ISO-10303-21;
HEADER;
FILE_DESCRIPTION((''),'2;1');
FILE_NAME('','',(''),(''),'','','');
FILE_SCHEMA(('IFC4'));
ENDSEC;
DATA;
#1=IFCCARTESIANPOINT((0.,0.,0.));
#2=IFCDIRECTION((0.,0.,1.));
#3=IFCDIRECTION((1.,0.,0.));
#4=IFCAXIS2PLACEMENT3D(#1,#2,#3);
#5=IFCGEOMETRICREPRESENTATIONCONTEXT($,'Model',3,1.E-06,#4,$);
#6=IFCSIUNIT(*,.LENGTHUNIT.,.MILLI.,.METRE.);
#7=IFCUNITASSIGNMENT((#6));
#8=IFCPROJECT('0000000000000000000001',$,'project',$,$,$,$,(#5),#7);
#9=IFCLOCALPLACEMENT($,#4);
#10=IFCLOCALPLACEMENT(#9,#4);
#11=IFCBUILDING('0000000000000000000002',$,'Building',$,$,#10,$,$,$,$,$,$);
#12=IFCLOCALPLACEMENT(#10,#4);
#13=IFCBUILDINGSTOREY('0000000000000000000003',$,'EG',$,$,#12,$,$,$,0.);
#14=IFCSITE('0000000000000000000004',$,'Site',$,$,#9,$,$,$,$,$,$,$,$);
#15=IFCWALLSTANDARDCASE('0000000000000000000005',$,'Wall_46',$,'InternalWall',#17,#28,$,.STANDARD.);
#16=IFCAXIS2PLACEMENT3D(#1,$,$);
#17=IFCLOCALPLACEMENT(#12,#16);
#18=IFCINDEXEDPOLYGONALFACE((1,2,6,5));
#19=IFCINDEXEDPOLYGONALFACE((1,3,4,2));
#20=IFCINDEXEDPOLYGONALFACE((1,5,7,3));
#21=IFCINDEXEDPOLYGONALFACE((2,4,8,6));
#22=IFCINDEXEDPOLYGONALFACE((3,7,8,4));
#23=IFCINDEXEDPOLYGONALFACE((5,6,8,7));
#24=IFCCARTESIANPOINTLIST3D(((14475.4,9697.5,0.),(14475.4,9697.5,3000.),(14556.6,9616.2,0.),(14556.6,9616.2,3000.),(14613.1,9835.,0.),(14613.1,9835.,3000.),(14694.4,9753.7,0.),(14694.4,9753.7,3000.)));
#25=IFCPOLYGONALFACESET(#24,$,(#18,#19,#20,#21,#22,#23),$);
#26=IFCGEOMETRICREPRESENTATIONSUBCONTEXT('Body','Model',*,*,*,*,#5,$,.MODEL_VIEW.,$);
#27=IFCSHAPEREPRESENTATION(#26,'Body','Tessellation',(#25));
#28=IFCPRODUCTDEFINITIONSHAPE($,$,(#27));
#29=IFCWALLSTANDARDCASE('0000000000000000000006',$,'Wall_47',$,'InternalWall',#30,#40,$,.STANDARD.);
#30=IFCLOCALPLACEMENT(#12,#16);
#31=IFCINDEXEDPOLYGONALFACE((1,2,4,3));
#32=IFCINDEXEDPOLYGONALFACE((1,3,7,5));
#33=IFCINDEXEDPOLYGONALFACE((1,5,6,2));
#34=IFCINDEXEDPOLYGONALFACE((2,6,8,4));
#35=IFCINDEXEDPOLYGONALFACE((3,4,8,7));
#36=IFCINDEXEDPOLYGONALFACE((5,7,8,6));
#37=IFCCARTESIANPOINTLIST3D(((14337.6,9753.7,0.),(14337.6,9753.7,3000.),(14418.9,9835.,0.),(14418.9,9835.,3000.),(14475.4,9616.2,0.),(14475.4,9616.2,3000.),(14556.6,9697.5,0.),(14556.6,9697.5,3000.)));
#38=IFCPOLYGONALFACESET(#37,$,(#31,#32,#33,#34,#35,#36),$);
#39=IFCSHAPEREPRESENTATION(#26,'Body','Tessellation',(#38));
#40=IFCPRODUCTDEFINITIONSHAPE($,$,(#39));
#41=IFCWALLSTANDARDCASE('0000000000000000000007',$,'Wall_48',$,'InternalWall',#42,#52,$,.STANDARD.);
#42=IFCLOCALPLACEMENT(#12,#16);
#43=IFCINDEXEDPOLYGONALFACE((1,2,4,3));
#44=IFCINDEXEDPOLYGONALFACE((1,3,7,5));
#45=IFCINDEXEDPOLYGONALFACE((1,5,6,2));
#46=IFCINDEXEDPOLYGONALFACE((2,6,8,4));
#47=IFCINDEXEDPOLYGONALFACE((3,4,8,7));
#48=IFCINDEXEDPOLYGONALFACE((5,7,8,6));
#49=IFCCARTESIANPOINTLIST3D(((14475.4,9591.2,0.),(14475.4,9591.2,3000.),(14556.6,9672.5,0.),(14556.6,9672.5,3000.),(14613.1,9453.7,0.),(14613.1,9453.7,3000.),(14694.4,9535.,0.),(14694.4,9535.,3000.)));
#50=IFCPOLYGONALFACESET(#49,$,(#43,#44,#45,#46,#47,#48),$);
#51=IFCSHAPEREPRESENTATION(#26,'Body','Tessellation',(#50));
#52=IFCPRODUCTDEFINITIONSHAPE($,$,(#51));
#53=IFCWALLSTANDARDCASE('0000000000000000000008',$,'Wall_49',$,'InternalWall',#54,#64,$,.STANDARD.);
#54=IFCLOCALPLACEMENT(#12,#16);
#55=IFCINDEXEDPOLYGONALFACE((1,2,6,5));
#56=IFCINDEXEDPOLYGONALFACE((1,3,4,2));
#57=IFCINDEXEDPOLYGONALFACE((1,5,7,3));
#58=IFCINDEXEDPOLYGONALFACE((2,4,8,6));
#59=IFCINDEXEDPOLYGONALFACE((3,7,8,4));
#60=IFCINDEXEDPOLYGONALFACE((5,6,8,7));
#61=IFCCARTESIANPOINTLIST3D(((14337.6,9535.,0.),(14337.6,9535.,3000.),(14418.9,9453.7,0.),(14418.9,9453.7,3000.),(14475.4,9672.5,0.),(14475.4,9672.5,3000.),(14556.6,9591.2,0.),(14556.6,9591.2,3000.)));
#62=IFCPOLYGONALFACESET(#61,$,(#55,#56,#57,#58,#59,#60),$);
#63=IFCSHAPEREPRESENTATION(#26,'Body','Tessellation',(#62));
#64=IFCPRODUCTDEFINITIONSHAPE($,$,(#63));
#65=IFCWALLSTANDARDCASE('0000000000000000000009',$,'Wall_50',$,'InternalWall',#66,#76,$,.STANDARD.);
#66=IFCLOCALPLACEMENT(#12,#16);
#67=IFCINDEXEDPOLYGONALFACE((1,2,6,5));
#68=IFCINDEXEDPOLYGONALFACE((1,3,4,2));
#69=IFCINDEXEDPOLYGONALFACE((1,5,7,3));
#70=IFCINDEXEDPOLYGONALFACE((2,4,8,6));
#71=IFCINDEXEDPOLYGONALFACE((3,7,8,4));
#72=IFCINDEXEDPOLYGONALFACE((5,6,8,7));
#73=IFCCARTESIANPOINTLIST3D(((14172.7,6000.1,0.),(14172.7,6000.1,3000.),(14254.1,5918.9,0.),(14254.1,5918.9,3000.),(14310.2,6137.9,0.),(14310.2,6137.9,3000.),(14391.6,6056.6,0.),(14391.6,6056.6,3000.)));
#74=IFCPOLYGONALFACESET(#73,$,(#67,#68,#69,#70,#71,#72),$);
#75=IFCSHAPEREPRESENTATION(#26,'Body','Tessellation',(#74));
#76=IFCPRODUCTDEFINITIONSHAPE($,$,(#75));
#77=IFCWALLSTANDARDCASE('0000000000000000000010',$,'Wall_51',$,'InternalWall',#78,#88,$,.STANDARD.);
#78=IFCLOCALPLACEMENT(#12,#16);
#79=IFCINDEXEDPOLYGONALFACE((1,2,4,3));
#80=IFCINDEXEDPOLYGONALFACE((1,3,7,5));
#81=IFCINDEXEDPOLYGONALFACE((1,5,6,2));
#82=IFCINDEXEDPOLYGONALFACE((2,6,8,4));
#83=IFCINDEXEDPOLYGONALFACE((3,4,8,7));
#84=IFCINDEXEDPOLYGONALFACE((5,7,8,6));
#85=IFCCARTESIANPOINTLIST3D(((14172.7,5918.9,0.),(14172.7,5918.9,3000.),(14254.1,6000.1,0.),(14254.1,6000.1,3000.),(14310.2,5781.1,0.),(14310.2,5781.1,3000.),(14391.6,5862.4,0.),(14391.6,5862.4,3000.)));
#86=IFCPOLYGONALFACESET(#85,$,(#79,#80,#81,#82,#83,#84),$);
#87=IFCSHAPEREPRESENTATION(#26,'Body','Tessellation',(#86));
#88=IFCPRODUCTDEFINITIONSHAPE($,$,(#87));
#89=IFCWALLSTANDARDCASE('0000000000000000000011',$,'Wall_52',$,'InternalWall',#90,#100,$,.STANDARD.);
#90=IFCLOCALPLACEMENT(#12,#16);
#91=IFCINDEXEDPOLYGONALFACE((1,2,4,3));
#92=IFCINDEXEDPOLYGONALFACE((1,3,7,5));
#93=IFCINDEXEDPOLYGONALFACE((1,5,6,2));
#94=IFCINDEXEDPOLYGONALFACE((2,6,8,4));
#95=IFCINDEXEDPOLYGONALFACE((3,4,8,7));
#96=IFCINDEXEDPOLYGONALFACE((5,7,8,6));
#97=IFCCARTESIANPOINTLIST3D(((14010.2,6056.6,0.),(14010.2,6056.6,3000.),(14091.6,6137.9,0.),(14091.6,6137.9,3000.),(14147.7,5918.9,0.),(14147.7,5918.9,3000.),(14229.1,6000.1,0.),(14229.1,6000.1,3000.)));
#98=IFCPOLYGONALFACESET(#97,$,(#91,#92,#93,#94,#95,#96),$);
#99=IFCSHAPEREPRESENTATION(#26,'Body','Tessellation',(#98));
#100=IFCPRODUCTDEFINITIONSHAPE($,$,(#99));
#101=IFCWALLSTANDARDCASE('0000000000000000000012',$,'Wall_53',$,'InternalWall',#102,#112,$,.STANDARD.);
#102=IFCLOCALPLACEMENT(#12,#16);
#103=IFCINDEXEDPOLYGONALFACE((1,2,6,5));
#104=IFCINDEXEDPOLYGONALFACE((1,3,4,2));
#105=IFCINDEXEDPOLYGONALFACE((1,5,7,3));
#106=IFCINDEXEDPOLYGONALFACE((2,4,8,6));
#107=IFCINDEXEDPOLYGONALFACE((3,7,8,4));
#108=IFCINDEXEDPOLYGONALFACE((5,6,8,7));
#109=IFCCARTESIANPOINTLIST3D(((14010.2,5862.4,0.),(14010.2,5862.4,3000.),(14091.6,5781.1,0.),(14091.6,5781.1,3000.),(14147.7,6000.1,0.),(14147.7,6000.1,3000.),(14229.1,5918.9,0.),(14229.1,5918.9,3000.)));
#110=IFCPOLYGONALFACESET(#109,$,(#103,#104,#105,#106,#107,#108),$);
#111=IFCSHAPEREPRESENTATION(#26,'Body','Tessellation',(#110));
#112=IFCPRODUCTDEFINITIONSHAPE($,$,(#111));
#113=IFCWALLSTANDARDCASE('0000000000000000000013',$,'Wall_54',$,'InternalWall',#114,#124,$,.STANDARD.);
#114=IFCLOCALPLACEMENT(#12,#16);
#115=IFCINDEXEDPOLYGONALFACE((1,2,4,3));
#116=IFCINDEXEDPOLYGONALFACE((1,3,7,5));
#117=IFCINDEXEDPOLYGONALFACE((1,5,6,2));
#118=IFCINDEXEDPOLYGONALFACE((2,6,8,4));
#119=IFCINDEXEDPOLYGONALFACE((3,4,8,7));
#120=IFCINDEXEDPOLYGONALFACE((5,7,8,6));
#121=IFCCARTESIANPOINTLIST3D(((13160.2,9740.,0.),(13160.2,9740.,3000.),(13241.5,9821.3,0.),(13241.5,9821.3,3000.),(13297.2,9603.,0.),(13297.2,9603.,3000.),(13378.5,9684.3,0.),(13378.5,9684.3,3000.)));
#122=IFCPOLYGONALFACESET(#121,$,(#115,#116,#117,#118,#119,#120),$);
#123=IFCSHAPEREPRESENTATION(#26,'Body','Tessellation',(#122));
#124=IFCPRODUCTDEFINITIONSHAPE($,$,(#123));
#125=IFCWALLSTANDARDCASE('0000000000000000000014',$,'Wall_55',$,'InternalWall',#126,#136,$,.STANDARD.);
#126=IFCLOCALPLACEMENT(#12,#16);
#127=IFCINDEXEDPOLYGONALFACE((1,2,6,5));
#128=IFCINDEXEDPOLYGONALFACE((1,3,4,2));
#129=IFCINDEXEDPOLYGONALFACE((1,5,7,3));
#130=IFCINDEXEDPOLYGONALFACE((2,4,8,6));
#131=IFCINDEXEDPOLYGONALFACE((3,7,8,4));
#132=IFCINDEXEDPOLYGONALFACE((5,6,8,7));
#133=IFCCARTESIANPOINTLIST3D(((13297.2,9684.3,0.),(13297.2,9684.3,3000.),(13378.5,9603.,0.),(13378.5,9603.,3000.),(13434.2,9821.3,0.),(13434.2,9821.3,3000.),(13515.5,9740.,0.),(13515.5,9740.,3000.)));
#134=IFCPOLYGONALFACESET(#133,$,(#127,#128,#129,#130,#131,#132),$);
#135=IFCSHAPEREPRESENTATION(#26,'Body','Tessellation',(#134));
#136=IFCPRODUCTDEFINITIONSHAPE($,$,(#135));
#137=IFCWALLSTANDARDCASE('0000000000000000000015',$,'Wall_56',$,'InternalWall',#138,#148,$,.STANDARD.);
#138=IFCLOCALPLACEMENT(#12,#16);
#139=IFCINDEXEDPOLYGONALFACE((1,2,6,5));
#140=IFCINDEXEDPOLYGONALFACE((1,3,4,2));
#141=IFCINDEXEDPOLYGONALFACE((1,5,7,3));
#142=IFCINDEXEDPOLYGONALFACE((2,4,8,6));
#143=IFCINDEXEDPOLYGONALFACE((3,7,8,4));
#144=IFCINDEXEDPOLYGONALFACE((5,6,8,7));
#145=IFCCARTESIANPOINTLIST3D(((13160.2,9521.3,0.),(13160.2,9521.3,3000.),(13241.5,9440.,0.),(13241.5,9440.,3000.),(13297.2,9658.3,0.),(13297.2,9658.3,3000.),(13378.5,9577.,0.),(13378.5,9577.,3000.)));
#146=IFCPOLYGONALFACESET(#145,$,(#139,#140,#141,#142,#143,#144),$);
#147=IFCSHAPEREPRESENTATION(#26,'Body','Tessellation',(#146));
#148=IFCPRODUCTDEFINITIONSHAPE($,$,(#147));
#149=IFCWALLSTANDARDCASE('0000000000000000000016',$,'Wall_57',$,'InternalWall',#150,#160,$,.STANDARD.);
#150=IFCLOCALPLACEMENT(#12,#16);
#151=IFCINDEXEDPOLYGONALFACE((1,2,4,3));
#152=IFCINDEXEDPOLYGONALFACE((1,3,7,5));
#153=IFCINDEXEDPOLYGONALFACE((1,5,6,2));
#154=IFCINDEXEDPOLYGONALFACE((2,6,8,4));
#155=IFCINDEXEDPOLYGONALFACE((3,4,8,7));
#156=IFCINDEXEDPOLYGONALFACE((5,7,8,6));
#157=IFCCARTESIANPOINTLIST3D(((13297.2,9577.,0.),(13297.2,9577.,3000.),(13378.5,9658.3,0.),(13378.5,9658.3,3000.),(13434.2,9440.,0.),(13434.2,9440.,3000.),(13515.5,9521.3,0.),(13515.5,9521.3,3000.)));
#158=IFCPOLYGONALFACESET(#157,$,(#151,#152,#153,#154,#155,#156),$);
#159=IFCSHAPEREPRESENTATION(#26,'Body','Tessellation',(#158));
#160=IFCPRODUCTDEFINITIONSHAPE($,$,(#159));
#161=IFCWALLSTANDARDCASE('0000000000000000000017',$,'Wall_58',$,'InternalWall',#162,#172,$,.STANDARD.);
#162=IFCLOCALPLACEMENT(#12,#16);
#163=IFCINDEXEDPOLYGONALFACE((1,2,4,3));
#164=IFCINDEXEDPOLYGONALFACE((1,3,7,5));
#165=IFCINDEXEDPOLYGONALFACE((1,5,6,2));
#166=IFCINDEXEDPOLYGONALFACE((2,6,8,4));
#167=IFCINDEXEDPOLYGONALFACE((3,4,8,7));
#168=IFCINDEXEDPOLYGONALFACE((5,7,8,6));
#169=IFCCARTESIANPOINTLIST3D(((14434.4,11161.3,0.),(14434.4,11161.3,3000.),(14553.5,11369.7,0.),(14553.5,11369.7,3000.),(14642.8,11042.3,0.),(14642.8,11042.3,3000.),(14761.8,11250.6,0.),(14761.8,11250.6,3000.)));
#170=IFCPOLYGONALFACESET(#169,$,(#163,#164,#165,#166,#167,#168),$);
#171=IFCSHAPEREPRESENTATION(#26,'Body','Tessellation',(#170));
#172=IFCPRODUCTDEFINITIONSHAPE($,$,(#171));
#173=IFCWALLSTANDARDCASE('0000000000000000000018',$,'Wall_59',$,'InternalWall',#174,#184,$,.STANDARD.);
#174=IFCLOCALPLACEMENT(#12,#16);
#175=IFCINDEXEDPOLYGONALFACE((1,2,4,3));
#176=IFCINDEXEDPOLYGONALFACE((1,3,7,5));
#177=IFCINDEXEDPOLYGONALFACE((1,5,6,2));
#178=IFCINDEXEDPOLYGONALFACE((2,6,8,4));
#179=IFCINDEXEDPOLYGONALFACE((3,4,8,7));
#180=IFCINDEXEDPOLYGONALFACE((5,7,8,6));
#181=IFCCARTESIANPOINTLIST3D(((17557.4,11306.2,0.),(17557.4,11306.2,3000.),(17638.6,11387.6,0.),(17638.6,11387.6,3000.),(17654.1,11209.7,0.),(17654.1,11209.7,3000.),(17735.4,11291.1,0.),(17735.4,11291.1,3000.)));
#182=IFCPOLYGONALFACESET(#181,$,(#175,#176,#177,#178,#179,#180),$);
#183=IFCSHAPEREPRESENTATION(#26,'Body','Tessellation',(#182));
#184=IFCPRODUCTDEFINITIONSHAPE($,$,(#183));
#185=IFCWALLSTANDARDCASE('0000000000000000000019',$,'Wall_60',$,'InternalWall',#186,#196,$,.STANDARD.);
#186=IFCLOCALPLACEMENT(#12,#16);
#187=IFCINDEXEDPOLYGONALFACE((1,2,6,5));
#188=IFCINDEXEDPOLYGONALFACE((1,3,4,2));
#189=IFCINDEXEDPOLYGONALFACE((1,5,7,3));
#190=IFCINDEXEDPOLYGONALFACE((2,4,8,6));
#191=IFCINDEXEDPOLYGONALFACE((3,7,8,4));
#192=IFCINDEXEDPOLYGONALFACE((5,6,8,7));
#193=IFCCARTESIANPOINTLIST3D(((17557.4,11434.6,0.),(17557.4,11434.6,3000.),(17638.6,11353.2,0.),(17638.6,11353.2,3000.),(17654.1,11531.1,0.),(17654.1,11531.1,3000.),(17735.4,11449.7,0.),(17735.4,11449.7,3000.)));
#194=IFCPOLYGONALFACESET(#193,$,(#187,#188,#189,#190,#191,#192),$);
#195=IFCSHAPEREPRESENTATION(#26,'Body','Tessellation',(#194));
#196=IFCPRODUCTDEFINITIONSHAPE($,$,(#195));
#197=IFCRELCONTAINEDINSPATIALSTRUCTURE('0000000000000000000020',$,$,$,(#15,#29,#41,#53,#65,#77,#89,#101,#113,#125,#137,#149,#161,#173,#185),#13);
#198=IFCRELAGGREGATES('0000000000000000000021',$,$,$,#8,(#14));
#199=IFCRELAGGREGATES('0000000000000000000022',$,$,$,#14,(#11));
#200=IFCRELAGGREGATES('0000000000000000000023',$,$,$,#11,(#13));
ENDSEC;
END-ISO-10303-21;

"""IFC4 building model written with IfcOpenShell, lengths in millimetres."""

from ifc_helpers import new_model, si_unit, frame, origin_with_axes, place, context, subcontext, project, spatial, rectangle, extrude, element, save


model = new_model("IFC4")

# Units and contexts
model_context = context("Model", 3, precision=1e-06, world=origin_with_axes())
body_context = subcontext(model_context, "Body", "Model", "MODEL_VIEW")
ifc_project = project(units=[si_unit("LENGTHUNIT", "METRE", prefix="MILLI")], contexts=[model_context])

# Site, building, storey
site_placement = place(None, origin_with_axes())
site = spatial("IfcSite", under=ifc_project, at=site_placement, Name="Site")
building_placement = place(site_placement, origin_with_axes())
building = spatial("IfcBuilding", under=site, at=building_placement, Name="Building")
storey_placement = place(building_placement, origin_with_axes())
storey = spatial("IfcBuildingStorey", under=building, at=storey_placement, Name="EG", Elevation=0.0)

# Walls
wall_1_placement = place(storey_placement, origin_with_axes())
element("IfcWallStandardCase", 1, at=wall_1_placement, inside=storey, Name="Wall_46", ObjectType="InternalWall", PredefinedType="STANDARD", context=body_context, shape_type="SweptSolid", body=[
    extrude(rectangle(XDim=194.6, YDim=115.0), frame((14584.9, 9725.6, 0.0), z_axis=(0.0, 0.0, 1.0), x_axis=(-0.707749, -0.706464, 0.0)), (0.0, 0.0, 1.0), 3000.0),
])
wall_2_placement = place(storey_placement, origin_with_axes())
element("IfcWallStandardCase", 2, at=wall_2_placement, inside=storey, Name="Wall_47", ObjectType="InternalWall", PredefinedType="STANDARD", context=body_context, shape_type="SweptSolid", body=[
    extrude(rectangle(XDim=194.6, YDim=115.0), frame((14447.1, 9725.6, 0.0), z_axis=(0.0, 0.0, 1.0), x_axis=(-0.707749, 0.706464, 0.0)), (0.0, 0.0, 1.0), 3000.0),
])
wall_3_placement = place(storey_placement, origin_with_axes())
element("IfcWallStandardCase", 3, at=wall_3_placement, inside=storey, Name="Wall_48", ObjectType="InternalWall", PredefinedType="STANDARD", context=body_context, shape_type="SweptSolid", body=[
    extrude(rectangle(XDim=194.6, YDim=115.0), frame((14584.9, 9563.1, 0.0), z_axis=(0.0, 0.0, 1.0), x_axis=(0.707749, -0.706464, 0.0)), (0.0, 0.0, 1.0), 3000.0),
])
wall_4_placement = place(storey_placement, origin_with_axes())
element("IfcWallStandardCase", 4, at=wall_4_placement, inside=storey, Name="Wall_49", ObjectType="InternalWall", PredefinedType="STANDARD", context=body_context, shape_type="SweptSolid", body=[
    extrude(rectangle(XDim=194.6, YDim=115.0), frame((14447.1, 9563.1, 0.0), z_axis=(0.0, 0.0, 1.0), x_axis=(-0.707749, -0.706464, 0.0)), (0.0, 0.0, 1.0), 3000.0),
])
wall_5_placement = place(storey_placement, origin_with_axes())
element("IfcWallStandardCase", 5, at=wall_5_placement, inside=storey, Name="Wall_50", ObjectType="InternalWall", PredefinedType="STANDARD", context=body_context, shape_type="SweptSolid", body=[
    extrude(rectangle(XDim=194.6, YDim=115.0), frame((14282.1, 6028.4, 0.0), z_axis=(0.0, 0.0, 1.0), x_axis=(0.706464, 0.707749, 0.0)), (0.0, 0.0, 1.0), 3000.0),
])
wall_6_placement = place(storey_placement, origin_with_axes())
element("IfcWallStandardCase", 6, at=wall_6_placement, inside=storey, Name="Wall_51", ObjectType="InternalWall", PredefinedType="STANDARD", context=body_context, shape_type="SweptSolid", body=[
    extrude(rectangle(XDim=194.6, YDim=115.0), frame((14282.1, 5890.6, 0.0), z_axis=(0.0, 0.0, 1.0), x_axis=(0.706464, -0.707749, 0.0)), (0.0, 0.0, 1.0), 3000.0),
])
wall_7_placement = place(storey_placement, origin_with_axes())
element("IfcWallStandardCase", 7, at=wall_7_placement, inside=storey, Name="Wall_52", ObjectType="InternalWall", PredefinedType="STANDARD", context=body_context, shape_type="SweptSolid", body=[
    extrude(rectangle(XDim=194.6, YDim=115.0), frame((14119.6, 6028.4, 0.0), z_axis=(0.0, 0.0, 1.0), x_axis=(-0.706464, 0.707749, 0.0)), (0.0, 0.0, 1.0), 3000.0),
])
wall_8_placement = place(storey_placement, origin_with_axes())
element("IfcWallStandardCase", 8, at=wall_8_placement, inside=storey, Name="Wall_53", ObjectType="InternalWall", PredefinedType="STANDARD", context=body_context, shape_type="SweptSolid", body=[
    extrude(rectangle(XDim=194.6, YDim=115.0), frame((14119.6, 5890.6, 0.0), z_axis=(0.0, 0.0, 1.0), x_axis=(-0.706464, -0.707749, 0.0)), (0.0, 0.0, 1.0), 3000.0),
])
wall_9_placement = place(storey_placement, origin_with_axes())
element("IfcWallStandardCase", 9, at=wall_9_placement, inside=storey, Name="Wall_54", ObjectType="InternalWall", PredefinedType="STANDARD", context=body_context, shape_type="SweptSolid", body=[
    extrude(rectangle(XDim=193.7, YDim=115.0), frame((13269.4, 9712.2, 0.0), z_axis=(0.0, 0.0, 1.0), x_axis=(0.707107, -0.707107, 0.0)), (0.0, 0.0, 1.0), 3000.0),
])
wall_10_placement = place(storey_placement, origin_with_axes())
element("IfcWallStandardCase", 10, at=wall_10_placement, inside=storey, Name="Wall_55", ObjectType="InternalWall", PredefinedType="STANDARD", context=body_context, shape_type="SweptSolid", body=[
    extrude(rectangle(XDim=193.7, YDim=115.0), frame((13406.4, 9712.2, 0.0), z_axis=(0.0, 0.0, 1.0), x_axis=(0.707107, 0.707107, 0.0)), (0.0, 0.0, 1.0), 3000.0),
])
wall_11_placement = place(storey_placement, origin_with_axes())
element("IfcWallStandardCase", 11, at=wall_11_placement, inside=storey, Name="Wall_56", ObjectType="InternalWall", PredefinedType="STANDARD", context=body_context, shape_type="SweptSolid", body=[
    extrude(rectangle(XDim=193.7, YDim=115.0), frame((13269.4, 9549.2, 0.0), z_axis=(0.0, 0.0, 1.0), x_axis=(-0.707107, -0.707107, 0.0)), (0.0, 0.0, 1.0), 3000.0),
])
wall_12_placement = place(storey_placement, origin_with_axes())
element("IfcWallStandardCase", 12, at=wall_12_placement, inside=storey, Name="Wall_57", ObjectType="InternalWall", PredefinedType="STANDARD", context=body_context, shape_type="SweptSolid", body=[
    extrude(rectangle(XDim=193.7, YDim=115.0), frame((13406.4, 9549.2, 0.0), z_axis=(0.0, 0.0, 1.0), x_axis=(0.707107, -0.707107, 0.0)), (0.0, 0.0, 1.0), 3000.0),
])
wall_13_placement = place(storey_placement, origin_with_axes())
element("IfcWallStandardCase", 13, at=wall_13_placement, inside=storey, Name="Wall_58", ObjectType="InternalWall", PredefinedType="STANDARD", context=body_context, shape_type="SweptSolid", body=[
    extrude(rectangle(XDim=240.0, YDim=240.0), frame((14598.1, 11206.0, 0.0), z_axis=(0.0, 0.0, 1.0), x_axis=(-0.868243, 0.496139, 0.0)), (0.0, 0.0, 1.0), 3000.0),
])
wall_14_placement = place(storey_placement, origin_with_axes())
element("IfcWallStandardCase", 14, at=wall_14_placement, inside=storey, Name="Wall_59", ObjectType="InternalWall", PredefinedType="STANDARD", context=body_context, shape_type="SweptSolid", body=[
    extrude(rectangle(XDim=136.6, YDim=115.0), frame((17646.4, 11298.6, 0.0), z_axis=(0.0, 0.0, 1.0), x_axis=(0.708021, -0.706191, 0.0)), (0.0, 0.0, 1.0), 3000.0),
])
wall_15_placement = place(storey_placement, origin_with_axes())
element("IfcWallStandardCase", 15, at=wall_15_placement, inside=storey, Name="Wall_60", ObjectType="InternalWall", PredefinedType="STANDARD", context=body_context, shape_type="SweptSolid", body=[
    extrude(rectangle(XDim=136.6, YDim=115.0), frame((17646.4, 11442.1, 0.0), z_axis=(0.0, 0.0, 1.0), x_axis=(0.708021, 0.706191, 0.0)), (0.0, 0.0, 1.0), 3000.0),
])

save(model, "model.ifc")
